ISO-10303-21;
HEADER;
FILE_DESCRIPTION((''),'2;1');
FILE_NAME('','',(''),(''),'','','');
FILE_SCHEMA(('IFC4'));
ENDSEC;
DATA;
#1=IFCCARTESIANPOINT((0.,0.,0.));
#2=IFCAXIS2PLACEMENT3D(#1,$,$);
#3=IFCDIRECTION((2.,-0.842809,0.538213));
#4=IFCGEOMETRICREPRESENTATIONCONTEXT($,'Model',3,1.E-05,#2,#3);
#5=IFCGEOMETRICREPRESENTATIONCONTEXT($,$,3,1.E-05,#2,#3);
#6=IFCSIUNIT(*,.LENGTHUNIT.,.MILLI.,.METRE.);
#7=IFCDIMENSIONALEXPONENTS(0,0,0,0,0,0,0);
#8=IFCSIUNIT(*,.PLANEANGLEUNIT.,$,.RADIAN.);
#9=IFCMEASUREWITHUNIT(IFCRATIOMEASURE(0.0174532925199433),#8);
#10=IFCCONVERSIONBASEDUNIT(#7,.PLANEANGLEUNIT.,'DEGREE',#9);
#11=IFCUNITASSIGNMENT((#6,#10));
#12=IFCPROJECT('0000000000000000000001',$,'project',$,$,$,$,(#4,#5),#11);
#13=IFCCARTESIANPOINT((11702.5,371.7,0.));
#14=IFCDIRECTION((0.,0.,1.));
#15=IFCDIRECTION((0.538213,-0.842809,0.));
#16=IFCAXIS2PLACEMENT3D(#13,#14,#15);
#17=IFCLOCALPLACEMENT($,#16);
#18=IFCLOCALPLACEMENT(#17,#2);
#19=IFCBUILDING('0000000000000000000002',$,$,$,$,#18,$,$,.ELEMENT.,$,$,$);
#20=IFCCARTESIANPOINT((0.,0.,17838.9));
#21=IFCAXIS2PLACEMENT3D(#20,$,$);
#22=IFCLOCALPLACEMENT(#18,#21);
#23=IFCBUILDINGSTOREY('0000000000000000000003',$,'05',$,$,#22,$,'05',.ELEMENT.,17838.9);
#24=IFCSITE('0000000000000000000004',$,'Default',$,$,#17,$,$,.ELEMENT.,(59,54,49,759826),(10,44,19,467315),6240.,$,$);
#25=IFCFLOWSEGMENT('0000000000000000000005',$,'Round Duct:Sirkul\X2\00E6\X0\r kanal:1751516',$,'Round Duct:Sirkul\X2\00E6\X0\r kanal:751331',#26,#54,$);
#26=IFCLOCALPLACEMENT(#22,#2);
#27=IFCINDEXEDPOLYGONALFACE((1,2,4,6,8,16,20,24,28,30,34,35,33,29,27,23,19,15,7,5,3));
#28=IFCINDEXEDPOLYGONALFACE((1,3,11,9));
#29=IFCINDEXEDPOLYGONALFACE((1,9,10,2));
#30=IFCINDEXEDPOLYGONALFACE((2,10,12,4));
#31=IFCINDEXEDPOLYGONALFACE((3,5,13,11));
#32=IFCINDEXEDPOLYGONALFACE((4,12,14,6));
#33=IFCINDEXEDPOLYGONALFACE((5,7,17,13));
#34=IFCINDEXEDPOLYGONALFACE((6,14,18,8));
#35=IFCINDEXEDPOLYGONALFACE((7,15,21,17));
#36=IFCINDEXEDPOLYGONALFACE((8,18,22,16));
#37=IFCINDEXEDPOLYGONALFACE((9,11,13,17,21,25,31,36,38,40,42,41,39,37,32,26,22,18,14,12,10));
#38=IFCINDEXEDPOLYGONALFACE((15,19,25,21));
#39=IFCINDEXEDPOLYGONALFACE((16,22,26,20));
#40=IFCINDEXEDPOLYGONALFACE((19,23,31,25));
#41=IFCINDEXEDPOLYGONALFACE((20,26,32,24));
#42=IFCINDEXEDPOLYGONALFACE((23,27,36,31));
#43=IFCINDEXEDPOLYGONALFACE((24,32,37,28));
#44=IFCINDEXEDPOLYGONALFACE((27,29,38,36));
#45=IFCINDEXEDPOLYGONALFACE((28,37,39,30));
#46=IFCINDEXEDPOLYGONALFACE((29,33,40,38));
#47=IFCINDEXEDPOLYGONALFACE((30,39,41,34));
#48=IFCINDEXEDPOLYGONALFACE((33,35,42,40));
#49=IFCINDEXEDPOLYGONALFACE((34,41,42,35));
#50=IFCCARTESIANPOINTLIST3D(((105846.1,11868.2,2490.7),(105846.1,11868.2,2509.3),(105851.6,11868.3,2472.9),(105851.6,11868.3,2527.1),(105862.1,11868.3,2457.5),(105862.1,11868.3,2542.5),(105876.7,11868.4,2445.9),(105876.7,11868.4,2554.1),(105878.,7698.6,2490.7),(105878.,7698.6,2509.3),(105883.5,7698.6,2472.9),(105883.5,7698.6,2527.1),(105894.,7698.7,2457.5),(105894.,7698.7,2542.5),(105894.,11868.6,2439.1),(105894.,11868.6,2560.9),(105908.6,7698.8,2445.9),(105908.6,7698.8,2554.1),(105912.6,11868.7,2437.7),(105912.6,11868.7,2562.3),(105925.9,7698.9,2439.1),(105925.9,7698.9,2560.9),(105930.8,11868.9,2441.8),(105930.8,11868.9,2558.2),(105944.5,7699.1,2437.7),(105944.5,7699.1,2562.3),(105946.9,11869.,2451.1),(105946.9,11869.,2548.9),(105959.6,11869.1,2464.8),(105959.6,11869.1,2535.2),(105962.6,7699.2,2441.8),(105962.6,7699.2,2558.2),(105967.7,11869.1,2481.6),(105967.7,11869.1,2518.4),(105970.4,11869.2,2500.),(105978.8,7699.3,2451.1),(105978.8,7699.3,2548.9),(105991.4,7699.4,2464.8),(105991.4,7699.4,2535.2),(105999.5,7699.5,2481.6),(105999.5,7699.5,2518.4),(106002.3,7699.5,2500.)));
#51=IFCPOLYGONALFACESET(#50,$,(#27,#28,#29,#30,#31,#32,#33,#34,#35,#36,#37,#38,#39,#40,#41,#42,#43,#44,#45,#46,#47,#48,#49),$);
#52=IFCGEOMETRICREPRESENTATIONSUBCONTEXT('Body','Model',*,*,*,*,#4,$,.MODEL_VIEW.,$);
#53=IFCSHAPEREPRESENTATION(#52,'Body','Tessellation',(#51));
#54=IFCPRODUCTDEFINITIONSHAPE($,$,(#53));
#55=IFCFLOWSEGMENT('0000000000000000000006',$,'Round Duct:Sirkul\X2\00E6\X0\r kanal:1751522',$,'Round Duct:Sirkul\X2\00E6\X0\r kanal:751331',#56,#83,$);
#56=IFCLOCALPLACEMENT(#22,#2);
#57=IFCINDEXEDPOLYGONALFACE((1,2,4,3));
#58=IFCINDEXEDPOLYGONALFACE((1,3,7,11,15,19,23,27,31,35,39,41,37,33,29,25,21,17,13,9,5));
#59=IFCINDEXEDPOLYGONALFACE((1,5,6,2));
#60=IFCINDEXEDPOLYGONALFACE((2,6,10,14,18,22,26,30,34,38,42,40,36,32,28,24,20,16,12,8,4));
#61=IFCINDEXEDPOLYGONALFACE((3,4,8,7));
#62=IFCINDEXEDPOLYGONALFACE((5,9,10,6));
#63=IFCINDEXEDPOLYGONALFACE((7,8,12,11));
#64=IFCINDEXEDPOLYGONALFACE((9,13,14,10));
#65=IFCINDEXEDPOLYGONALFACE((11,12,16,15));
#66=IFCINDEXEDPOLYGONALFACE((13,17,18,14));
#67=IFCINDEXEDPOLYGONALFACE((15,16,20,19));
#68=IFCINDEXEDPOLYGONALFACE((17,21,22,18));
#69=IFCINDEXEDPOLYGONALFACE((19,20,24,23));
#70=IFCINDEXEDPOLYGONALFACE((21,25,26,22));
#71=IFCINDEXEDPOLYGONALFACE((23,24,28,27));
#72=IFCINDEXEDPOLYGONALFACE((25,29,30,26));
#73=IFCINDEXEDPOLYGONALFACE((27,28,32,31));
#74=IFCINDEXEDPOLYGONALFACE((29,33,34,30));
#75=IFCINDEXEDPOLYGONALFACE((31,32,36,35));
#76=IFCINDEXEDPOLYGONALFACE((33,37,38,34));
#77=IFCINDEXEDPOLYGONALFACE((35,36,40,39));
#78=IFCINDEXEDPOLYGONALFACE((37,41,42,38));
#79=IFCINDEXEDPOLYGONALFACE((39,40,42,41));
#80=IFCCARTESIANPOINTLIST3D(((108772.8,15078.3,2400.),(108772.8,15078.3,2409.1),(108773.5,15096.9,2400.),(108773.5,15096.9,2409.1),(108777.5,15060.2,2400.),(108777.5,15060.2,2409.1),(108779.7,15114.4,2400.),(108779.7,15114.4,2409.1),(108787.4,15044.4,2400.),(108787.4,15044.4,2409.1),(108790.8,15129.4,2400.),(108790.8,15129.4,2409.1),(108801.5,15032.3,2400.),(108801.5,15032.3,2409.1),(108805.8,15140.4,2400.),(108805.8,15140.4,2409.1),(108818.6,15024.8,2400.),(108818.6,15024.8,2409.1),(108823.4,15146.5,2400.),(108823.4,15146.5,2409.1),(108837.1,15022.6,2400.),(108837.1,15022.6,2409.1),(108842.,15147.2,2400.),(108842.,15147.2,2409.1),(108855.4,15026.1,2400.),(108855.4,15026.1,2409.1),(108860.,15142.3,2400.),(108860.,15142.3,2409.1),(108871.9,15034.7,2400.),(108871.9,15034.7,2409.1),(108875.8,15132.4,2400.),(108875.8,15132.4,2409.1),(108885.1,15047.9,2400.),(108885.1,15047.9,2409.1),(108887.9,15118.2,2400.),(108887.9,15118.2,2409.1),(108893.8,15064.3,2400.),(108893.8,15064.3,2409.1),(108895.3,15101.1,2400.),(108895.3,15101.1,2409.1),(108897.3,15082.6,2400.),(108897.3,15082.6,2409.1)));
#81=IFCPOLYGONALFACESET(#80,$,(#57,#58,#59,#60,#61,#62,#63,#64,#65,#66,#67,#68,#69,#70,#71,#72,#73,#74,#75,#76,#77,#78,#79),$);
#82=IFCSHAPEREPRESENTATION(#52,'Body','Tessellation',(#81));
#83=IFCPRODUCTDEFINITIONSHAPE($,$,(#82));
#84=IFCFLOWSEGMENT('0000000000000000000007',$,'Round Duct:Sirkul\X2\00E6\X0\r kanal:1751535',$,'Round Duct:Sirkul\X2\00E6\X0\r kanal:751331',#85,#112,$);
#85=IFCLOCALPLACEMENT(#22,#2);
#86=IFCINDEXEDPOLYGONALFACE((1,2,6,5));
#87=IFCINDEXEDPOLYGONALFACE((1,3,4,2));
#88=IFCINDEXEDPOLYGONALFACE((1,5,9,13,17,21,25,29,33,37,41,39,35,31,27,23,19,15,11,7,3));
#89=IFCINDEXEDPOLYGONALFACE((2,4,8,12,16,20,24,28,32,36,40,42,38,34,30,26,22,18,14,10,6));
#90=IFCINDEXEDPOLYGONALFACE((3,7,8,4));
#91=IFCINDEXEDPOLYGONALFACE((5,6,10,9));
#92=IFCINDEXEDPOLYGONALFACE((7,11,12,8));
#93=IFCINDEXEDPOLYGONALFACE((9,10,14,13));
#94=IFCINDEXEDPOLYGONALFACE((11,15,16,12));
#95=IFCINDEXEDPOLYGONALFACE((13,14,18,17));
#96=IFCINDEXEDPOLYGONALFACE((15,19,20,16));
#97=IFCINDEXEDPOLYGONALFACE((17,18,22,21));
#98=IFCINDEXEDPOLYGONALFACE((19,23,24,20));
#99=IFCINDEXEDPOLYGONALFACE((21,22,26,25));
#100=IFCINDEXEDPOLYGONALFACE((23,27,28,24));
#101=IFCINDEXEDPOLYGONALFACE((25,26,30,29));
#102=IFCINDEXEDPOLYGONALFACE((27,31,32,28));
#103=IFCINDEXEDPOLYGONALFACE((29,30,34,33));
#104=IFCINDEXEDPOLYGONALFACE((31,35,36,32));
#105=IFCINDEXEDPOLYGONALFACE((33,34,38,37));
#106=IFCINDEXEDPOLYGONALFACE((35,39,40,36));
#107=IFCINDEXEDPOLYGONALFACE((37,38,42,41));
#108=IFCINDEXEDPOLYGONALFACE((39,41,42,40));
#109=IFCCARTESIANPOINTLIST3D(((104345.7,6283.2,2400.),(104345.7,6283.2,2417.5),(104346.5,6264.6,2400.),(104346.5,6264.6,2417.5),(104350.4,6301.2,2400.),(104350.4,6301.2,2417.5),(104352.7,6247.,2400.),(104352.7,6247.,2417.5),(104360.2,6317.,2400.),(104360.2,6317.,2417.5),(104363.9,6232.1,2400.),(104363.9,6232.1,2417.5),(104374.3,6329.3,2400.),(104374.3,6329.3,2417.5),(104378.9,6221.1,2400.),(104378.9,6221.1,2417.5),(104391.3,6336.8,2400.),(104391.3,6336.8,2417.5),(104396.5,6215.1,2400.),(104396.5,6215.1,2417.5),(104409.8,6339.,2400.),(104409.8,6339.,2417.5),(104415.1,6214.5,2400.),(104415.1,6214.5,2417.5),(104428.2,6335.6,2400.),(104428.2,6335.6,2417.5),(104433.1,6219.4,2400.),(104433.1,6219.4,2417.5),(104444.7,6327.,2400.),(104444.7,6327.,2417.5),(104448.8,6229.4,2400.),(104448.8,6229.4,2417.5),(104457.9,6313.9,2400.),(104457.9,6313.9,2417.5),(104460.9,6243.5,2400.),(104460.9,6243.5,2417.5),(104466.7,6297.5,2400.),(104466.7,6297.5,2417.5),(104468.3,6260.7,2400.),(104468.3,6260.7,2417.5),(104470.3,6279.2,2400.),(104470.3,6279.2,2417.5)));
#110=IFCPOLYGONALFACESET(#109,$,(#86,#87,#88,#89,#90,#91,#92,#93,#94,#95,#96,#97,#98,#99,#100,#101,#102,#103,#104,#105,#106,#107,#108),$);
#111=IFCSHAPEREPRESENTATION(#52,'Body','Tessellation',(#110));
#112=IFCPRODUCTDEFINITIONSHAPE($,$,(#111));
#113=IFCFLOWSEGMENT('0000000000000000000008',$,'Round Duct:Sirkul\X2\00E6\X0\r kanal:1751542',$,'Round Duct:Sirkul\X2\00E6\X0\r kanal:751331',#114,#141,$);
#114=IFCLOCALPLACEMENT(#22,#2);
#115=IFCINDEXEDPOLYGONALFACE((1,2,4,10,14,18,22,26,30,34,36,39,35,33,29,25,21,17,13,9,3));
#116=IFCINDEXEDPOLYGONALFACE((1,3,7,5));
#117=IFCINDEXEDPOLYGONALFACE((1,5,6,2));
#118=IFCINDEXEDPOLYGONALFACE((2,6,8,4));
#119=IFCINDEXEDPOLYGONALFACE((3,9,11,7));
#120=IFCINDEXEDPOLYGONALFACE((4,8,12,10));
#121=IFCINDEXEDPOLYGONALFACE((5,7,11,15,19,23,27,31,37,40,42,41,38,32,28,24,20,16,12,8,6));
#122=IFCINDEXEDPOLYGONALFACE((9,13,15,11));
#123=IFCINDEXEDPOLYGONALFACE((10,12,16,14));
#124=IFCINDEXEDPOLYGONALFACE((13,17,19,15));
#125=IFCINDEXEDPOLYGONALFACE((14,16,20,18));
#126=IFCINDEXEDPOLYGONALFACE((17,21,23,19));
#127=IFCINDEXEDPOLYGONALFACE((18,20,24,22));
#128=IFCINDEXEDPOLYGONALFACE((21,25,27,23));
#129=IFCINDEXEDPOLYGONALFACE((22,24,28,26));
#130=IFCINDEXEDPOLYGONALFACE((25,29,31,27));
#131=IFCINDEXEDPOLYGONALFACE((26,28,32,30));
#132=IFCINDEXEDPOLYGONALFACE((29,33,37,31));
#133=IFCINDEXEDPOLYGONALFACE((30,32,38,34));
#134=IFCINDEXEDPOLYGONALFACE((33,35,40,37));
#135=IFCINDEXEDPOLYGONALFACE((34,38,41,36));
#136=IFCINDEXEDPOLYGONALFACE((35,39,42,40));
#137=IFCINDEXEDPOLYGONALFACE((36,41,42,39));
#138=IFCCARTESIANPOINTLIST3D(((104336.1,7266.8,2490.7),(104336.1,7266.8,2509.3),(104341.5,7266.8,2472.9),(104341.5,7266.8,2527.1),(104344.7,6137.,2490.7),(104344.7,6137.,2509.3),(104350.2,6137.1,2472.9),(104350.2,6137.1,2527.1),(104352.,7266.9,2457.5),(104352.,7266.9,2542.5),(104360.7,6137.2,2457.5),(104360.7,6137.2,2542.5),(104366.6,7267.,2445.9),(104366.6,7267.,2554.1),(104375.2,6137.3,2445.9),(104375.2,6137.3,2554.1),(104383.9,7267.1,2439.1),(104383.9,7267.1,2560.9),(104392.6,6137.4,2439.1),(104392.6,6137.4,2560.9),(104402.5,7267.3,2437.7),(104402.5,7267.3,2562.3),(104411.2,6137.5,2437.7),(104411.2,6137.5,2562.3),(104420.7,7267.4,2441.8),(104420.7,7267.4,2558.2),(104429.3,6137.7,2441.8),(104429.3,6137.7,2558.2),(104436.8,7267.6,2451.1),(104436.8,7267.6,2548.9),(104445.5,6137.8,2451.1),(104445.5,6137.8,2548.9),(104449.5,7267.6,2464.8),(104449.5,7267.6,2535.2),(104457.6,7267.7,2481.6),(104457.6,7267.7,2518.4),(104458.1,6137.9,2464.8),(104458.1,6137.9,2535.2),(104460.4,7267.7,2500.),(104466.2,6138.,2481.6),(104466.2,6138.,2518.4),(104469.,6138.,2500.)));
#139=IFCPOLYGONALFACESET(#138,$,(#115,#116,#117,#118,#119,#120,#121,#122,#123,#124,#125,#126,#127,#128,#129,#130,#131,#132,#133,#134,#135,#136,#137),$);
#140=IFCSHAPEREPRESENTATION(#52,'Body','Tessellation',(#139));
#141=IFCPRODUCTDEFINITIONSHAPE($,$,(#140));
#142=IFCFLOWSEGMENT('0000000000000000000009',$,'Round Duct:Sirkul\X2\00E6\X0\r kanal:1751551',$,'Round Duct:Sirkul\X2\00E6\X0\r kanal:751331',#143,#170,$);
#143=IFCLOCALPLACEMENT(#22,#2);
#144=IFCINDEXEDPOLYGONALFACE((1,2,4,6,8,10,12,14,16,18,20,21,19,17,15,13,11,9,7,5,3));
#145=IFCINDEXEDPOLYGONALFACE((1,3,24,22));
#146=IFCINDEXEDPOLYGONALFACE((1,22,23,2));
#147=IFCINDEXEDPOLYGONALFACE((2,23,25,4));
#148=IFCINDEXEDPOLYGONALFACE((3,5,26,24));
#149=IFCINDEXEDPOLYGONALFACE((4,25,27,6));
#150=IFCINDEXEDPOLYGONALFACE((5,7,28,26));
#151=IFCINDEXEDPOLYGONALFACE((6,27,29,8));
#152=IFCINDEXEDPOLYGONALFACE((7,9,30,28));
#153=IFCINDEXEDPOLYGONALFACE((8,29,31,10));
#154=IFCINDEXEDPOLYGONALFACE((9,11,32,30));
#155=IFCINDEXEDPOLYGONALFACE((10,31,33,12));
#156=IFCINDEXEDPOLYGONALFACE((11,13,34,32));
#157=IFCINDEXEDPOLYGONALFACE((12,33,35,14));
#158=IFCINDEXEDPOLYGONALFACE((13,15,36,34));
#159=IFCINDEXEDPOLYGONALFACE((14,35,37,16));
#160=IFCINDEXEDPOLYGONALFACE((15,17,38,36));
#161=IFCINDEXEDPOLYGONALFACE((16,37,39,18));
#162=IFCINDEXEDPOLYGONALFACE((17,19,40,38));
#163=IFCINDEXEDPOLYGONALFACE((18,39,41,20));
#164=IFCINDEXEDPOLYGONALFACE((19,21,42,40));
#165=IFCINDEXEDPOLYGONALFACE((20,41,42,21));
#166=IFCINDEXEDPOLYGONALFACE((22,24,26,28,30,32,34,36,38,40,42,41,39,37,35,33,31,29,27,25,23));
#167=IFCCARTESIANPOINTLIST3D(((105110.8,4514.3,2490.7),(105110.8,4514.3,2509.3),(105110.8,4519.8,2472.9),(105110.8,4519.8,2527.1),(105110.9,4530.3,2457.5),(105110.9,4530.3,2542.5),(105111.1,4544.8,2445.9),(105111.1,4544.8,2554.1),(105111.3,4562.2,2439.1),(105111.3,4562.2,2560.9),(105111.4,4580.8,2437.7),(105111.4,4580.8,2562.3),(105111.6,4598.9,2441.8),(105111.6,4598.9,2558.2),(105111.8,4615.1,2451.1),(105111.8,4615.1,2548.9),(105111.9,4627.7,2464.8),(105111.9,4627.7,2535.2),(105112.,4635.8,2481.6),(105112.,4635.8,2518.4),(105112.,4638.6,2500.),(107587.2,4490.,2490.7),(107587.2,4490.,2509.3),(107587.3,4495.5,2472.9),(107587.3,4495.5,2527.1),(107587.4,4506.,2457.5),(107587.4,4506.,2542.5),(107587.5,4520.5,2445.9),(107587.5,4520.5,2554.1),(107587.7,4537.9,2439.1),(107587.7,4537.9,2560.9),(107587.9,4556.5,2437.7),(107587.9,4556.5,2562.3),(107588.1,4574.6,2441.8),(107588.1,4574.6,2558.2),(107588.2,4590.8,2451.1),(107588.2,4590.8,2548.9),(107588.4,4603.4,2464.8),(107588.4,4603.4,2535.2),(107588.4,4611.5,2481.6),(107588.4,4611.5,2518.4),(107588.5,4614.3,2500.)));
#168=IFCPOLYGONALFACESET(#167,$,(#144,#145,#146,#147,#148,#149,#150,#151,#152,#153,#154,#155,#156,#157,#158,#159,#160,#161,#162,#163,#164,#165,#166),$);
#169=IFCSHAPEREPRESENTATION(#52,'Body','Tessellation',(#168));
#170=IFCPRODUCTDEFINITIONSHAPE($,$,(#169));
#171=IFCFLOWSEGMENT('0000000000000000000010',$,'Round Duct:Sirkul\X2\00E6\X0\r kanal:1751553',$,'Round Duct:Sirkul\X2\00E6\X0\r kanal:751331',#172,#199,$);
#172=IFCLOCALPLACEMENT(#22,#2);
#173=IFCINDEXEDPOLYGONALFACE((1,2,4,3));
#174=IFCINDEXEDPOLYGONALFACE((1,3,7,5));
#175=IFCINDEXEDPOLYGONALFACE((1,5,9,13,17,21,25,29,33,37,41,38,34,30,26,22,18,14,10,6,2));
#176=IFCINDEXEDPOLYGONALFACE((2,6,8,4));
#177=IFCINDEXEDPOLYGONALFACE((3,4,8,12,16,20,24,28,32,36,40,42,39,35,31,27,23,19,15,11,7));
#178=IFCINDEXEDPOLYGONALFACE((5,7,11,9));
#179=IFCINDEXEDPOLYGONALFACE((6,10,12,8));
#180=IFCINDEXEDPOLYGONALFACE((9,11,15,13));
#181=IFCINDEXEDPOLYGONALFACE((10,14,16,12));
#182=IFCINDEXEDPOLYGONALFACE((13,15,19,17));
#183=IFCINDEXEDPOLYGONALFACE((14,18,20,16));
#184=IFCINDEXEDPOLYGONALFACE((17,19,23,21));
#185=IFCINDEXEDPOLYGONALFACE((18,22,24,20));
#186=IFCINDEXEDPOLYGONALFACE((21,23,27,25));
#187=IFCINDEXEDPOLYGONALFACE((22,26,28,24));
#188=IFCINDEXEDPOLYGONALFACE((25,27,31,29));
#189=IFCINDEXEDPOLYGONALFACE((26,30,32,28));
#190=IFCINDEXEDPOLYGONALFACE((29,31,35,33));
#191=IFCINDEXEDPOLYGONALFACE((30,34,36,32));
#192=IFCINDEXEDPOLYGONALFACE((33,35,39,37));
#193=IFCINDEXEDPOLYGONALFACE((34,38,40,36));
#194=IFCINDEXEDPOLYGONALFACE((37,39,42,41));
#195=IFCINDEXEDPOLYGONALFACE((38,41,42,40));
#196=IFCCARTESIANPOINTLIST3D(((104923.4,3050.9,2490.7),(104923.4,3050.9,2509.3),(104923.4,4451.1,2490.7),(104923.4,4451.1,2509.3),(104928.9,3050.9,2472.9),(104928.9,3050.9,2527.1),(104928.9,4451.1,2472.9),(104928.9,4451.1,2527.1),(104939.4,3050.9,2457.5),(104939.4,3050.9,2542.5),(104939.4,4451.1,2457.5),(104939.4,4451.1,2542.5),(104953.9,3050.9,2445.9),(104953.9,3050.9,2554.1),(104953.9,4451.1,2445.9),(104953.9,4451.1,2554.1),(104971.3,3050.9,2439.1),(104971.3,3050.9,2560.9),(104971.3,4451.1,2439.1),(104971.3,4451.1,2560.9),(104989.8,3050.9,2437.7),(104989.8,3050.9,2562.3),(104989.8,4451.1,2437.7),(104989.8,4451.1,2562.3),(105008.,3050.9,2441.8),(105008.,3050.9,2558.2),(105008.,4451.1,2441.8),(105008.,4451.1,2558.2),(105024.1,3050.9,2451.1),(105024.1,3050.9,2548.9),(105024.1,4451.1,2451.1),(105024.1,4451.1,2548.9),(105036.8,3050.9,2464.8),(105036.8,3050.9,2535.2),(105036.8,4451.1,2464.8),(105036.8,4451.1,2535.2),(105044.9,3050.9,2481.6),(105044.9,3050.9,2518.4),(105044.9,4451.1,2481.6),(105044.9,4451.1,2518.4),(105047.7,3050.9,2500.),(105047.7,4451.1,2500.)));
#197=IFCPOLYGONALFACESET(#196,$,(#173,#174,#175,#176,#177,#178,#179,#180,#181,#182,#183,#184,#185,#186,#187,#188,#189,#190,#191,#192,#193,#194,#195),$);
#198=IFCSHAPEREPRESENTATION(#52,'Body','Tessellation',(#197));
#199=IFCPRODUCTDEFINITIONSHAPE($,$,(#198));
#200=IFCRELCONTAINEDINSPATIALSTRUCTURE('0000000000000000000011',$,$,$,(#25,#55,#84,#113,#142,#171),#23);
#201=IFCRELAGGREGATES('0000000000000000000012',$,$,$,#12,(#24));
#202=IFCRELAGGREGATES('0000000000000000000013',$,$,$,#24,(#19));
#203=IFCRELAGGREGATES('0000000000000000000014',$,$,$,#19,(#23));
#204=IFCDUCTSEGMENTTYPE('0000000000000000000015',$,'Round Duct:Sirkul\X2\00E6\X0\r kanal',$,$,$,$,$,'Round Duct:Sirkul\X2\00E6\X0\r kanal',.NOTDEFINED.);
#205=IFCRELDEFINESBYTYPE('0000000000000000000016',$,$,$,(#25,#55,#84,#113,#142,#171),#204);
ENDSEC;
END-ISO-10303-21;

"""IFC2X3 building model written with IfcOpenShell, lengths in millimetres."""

from ifc_helpers import new_model, entity, si_unit, converted_unit, direction, frame, frame_2d, origin, origin_2d_with_axis, place, context, subcontext, project, spatial, circle, extrude, type_object, element, save


model = new_model("IFC2X3")

# Units and contexts
model_context = context("Model", 3, precision=1e-05, world=origin(), true_north=direction((2.0, -0.842809, 0.538213)))
context_of_model = context(None, 3, precision=1e-05, world=origin(), true_north=direction((2.0, -0.842809, 0.538213)))
body_context = subcontext(model_context, "Body", "Model", "MODEL_VIEW")
ifc_project = project(units=[si_unit("LENGTHUNIT", "METRE", prefix="MILLI"), converted_unit("PLANEANGLEUNIT", "DEGREE", entity("IfcRatioMeasure", 0.0174532925199433), si_unit("PLANEANGLEUNIT", "RADIAN"), dimensions=[0, 0, 0, 0, 0, 0, 0])], contexts=[model_context, context_of_model])

# Site, building, storey
site_placement = place(None, frame((11702.5, 371.7, 0.0), z_axis=(0.0, 0.0, 1.0), x_axis=(0.538213, -0.842809, 0.0)))
site = spatial("IfcSite", under=ifc_project, at=site_placement, Name="Default", CompositionType="ELEMENT", RefLatitude=(59, 54, 49, 759826), RefLongitude=(10, 44, 19, 467315), RefElevation=6240.0)
building_placement = place(site_placement, origin())
building = spatial("IfcBuilding", under=site, at=building_placement, CompositionType="ELEMENT")
storey_placement = place(building_placement, frame((0.0, 0.0, 17838.9)))
storey = spatial("IfcBuildingStorey", under=building, at=storey_placement, Name="05", LongName="05", CompositionType="ELEMENT", Elevation=17838.9)

# Flow segments
duct_segment_type = type_object("IfcDuctSegmentType", Name="Round Duct:Sirkulær kanal", ElementType="Round Duct:Sirkulær kanal", PredefinedType="NOTDEFINED")
flow_segment_1_placement = place(storey_placement, origin())
element("IfcFlowSegment", 1, at=flow_segment_1_placement, inside=storey, type_object=duct_segment_type, Name="Round Duct:Sirkulær kanal:1751516", ObjectType="Round Duct:Sirkulær kanal:751331", context=body_context, shape_type="SweptSolid", body=[
    extrude(circle(Radius=62.5, at=origin_2d_with_axis()), frame((105939.8, 7699.0, 2500.0), z_axis=(-0.007643, 0.999971, 0.0), x_axis=(0.999971, 0.007643, 0.0)), (0.0, 0.0, 1.0), 4169.8),
])
flow_segment_2_placement = place(storey_placement, origin())
element("IfcFlowSegment", 2, at=flow_segment_2_placement, inside=storey, type_object=duct_segment_type, Name="Round Duct:Sirkulær kanal:1751522", ObjectType="Round Duct:Sirkulær kanal:751331", context=body_context, shape_type="SweptSolid", body=[
    extrude(circle(Radius=62.5, at=frame_2d((0.0, 0.0), x_axis=(1.0, 0.0))), frame((108834.9, 15085.1, 2400.0), z_axis=(0.0, 0.0, 1.0), x_axis=(0.803212, -0.595694, 0.0)), (0.0, 0.0, 1.0), 9.1),
])
flow_segment_3_placement = place(storey_placement, origin())
element("IfcFlowSegment", 3, at=flow_segment_3_placement, inside=storey, type_object=duct_segment_type, Name="Round Duct:Sirkulær kanal:1751535", ObjectType="Round Duct:Sirkulær kanal:751331", context=body_context, shape_type="SweptSolid", body=[
    extrude(circle(Radius=62.5, at=frame_2d((0.0, 0.0), x_axis=(1.0, 0.0))), frame((104407.8, 6276.5, 2400.0), z_axis=(0.0, 0.0, 1.0), x_axis=(0.999095, 0.042537, 0.0)), (0.0, 0.0, 1.0), 17.5),
])
flow_segment_4_placement = place(storey_placement, origin())
element("IfcFlowSegment", 4, at=flow_segment_4_placement, inside=storey, type_object=duct_segment_type, Name="Round Duct:Sirkulær kanal:1751542", ObjectType="Round Duct:Sirkulær kanal:751331", context=body_context, shape_type="SweptSolid", body=[
    extrude(circle(Radius=62.5, at=origin_2d_with_axis()), frame((104406.5, 6137.5, 2500.0), z_axis=(-0.007643, 0.999971, 0.0), x_axis=(0.999971, 0.007643, 0.0)), (0.0, 0.0, 1.0), 1129.8),
])
flow_segment_5_placement = place(storey_placement, origin())
element("IfcFlowSegment", 5, at=flow_segment_5_placement, inside=storey, type_object=duct_segment_type, Name="Round Duct:Sirkulær kanal:1751551", ObjectType="Round Duct:Sirkulær kanal:751331", context=body_context, shape_type="SweptSolid", body=[
    extrude(circle(Radius=62.5, at=frame_2d((0.0, 0.0), x_axis=(1.0, 0.0))), frame((107587.8, 4551.8, 2500.0), z_axis=(-0.999952, 0.00981, 0.0), x_axis=(0.00981, 0.999952, 0.0)), (0.0, 0.0, 1.0), 2476.6),
])
flow_segment_6_placement = place(storey_placement, origin())
element("IfcFlowSegment", 6, at=flow_segment_6_placement, inside=storey, type_object=duct_segment_type, Name="Round Duct:Sirkulær kanal:1751553", ObjectType="Round Duct:Sirkulær kanal:751331", context=body_context, shape_type="SweptSolid", body=[
    extrude(circle(Radius=62.5, at=origin_2d_with_axis()), frame((104985.2, 3050.9, 2500.0), z_axis=(0.0, 1.0, 0.0), x_axis=(1.0, 0.0, 0.0)), (0.0, 0.0, 1.0), 1400.2),
])

save(model, "model.ifc")
